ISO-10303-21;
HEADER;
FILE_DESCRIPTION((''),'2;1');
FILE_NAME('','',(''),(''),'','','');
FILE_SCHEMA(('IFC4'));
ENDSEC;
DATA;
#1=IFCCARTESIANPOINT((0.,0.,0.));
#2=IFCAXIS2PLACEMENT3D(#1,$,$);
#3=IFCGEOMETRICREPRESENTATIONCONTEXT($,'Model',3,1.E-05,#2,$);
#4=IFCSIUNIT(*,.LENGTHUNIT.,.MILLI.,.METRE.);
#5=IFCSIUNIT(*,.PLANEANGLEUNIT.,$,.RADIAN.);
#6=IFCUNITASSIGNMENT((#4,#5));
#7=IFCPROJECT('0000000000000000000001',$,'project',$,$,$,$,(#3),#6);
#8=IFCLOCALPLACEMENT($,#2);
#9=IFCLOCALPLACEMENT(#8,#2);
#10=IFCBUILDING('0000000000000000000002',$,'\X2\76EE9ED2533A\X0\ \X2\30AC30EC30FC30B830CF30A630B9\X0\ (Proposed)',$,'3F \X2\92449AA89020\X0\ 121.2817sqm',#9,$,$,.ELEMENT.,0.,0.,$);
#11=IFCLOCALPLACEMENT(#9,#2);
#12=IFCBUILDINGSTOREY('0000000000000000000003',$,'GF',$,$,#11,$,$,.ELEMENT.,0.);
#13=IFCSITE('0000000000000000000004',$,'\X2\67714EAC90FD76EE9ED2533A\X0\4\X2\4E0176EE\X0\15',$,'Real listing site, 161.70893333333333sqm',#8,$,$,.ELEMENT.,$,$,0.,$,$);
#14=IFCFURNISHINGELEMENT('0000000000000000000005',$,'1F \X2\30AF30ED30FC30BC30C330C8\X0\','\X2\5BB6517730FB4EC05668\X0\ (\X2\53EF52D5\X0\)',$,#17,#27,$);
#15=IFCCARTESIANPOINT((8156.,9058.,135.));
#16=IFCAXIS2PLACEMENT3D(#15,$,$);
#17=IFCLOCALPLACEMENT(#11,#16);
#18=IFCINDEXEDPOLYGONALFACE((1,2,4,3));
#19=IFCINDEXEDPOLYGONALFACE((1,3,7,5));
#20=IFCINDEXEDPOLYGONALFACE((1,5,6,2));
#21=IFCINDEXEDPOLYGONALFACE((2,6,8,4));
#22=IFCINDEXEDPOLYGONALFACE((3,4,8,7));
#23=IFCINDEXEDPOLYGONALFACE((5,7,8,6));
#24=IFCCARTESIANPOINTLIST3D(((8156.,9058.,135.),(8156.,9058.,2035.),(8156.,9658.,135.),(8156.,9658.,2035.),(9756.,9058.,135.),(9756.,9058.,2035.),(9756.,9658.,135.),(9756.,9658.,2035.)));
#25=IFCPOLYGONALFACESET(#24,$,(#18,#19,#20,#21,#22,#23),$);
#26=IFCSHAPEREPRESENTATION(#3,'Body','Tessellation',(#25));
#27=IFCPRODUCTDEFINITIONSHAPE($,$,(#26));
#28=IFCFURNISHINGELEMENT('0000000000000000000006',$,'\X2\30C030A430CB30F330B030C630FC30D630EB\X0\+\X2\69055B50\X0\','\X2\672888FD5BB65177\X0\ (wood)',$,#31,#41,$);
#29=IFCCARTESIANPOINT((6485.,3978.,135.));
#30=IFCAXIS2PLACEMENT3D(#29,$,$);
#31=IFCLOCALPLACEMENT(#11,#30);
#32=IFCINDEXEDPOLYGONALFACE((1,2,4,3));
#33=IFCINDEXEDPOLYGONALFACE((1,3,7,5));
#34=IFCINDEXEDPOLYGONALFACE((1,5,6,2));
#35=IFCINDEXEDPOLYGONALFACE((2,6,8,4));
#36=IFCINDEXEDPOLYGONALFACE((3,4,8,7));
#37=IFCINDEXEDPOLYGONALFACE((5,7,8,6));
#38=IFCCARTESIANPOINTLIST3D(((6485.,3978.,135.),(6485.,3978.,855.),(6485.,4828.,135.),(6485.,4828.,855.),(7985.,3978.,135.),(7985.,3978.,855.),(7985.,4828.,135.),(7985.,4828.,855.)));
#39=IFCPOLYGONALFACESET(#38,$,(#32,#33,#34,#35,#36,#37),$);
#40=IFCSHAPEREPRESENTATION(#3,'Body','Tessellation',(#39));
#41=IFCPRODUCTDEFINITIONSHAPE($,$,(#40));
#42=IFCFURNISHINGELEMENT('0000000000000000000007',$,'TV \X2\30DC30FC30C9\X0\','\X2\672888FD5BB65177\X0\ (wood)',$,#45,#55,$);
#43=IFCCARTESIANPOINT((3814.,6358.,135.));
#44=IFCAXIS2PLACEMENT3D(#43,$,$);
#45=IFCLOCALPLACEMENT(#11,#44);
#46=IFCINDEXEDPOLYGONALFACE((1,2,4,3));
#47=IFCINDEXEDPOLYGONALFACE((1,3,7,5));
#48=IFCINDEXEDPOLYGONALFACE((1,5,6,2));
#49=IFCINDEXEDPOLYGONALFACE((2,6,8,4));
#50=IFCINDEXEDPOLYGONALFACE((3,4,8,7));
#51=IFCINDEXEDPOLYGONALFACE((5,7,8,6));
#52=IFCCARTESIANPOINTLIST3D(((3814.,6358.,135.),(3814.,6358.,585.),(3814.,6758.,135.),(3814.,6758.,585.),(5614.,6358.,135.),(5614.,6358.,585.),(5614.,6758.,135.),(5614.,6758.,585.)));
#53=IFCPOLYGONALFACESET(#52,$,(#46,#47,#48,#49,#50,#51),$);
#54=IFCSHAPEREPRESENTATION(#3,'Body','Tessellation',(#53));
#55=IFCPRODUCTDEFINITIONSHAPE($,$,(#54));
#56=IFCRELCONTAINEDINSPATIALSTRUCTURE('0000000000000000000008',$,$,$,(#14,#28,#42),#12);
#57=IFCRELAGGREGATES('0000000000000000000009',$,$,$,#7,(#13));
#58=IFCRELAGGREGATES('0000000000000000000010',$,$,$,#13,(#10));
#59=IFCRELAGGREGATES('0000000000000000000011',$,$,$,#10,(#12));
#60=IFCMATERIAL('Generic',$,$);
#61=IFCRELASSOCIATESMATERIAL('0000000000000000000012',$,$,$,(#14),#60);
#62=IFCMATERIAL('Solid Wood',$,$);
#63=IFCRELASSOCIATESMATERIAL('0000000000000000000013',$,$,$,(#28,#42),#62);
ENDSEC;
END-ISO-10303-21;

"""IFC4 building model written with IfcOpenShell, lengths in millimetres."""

from ifc_helpers import new_model, si_unit, frame, frame_2d, origin, place, context, project, spatial, rectangle, extrude, material, element, save


model = new_model("IFC4")

# Units and contexts
model_context = context("Model", 3, precision=1e-05, world=origin())
ifc_project = project(units=[si_unit("LENGTHUNIT", "METRE", prefix="MILLI"), si_unit("PLANEANGLEUNIT", "RADIAN")], contexts=[model_context])

# Site, building, storey
site_placement = place(None, origin())
site = spatial("IfcSite", under=ifc_project, at=site_placement, Name="東京都目黒区4丁目15", ObjectType="Real listing site, 161.70893333333333sqm", CompositionType="ELEMENT", RefElevation=0.0)
building_placement = place(site_placement, origin())
building = spatial("IfcBuilding", under=site, at=building_placement, Name="目黒区 ガレージハウス (Proposed)", ObjectType="3F 鉄骨造 121.2817sqm", CompositionType="ELEMENT", ElevationOfRefHeight=0.0, ElevationOfTerrain=0.0)
storey_placement = place(building_placement, origin())
storey = spatial("IfcBuildingStorey", under=building, at=storey_placement, Name="GF", CompositionType="ELEMENT", Elevation=0.0)

# Shared definitions
ifc_material_1 = material(Name="Solid Wood")

# Shared definitions
ifc_material_2 = material(Name="Generic")

# Furnishing elements
furnishing_1_placement = place(storey_placement, frame((8156.0, 9058.0, 135.0)))
element("IfcFurnishingElement", 1, at=furnishing_1_placement, inside=storey, material=ifc_material_2, Name="1F クローゼット", Description="家具・什器 (可動)", context=model_context, shape_type="SweptSolid", body=[
    extrude(rectangle(XDim=1600.0, YDim=600.0, at=frame_2d((800.0, 300.0))), frame((8156.0, 9058.0, 135.0)), (0.0, 0.0, 1.0), 1900.0),
])
furnishing_2_placement = place(storey_placement, frame((6485.0, 3978.0, 135.0)))
element("IfcFurnishingElement", 2, at=furnishing_2_placement, inside=storey, material=ifc_material_1, Name="ダイニングテーブル+椅子", Description="木製家具 (wood)", context=model_context, shape_type="SweptSolid", body=[
    extrude(rectangle(XDim=1500.0, YDim=850.0, at=frame_2d((750.0, 425.0))), frame((6485.0, 3978.0, 135.0)), (0.0, 0.0, 1.0), 720.0),
])
furnishing_3_placement = place(storey_placement, frame((3814.0, 6358.0, 135.0)))
element("IfcFurnishingElement", 3, at=furnishing_3_placement, inside=storey, material=ifc_material_1, Name="TV ボード", Description="木製家具 (wood)", context=model_context, shape_type="SweptSolid", body=[
    extrude(rectangle(XDim=1800.0, YDim=400.0, at=frame_2d((900.0, 200.0))), frame((3814.0, 6358.0, 135.0)), (0.0, 0.0, 1.0), 450.0),
])

save(model, "model.ifc")
